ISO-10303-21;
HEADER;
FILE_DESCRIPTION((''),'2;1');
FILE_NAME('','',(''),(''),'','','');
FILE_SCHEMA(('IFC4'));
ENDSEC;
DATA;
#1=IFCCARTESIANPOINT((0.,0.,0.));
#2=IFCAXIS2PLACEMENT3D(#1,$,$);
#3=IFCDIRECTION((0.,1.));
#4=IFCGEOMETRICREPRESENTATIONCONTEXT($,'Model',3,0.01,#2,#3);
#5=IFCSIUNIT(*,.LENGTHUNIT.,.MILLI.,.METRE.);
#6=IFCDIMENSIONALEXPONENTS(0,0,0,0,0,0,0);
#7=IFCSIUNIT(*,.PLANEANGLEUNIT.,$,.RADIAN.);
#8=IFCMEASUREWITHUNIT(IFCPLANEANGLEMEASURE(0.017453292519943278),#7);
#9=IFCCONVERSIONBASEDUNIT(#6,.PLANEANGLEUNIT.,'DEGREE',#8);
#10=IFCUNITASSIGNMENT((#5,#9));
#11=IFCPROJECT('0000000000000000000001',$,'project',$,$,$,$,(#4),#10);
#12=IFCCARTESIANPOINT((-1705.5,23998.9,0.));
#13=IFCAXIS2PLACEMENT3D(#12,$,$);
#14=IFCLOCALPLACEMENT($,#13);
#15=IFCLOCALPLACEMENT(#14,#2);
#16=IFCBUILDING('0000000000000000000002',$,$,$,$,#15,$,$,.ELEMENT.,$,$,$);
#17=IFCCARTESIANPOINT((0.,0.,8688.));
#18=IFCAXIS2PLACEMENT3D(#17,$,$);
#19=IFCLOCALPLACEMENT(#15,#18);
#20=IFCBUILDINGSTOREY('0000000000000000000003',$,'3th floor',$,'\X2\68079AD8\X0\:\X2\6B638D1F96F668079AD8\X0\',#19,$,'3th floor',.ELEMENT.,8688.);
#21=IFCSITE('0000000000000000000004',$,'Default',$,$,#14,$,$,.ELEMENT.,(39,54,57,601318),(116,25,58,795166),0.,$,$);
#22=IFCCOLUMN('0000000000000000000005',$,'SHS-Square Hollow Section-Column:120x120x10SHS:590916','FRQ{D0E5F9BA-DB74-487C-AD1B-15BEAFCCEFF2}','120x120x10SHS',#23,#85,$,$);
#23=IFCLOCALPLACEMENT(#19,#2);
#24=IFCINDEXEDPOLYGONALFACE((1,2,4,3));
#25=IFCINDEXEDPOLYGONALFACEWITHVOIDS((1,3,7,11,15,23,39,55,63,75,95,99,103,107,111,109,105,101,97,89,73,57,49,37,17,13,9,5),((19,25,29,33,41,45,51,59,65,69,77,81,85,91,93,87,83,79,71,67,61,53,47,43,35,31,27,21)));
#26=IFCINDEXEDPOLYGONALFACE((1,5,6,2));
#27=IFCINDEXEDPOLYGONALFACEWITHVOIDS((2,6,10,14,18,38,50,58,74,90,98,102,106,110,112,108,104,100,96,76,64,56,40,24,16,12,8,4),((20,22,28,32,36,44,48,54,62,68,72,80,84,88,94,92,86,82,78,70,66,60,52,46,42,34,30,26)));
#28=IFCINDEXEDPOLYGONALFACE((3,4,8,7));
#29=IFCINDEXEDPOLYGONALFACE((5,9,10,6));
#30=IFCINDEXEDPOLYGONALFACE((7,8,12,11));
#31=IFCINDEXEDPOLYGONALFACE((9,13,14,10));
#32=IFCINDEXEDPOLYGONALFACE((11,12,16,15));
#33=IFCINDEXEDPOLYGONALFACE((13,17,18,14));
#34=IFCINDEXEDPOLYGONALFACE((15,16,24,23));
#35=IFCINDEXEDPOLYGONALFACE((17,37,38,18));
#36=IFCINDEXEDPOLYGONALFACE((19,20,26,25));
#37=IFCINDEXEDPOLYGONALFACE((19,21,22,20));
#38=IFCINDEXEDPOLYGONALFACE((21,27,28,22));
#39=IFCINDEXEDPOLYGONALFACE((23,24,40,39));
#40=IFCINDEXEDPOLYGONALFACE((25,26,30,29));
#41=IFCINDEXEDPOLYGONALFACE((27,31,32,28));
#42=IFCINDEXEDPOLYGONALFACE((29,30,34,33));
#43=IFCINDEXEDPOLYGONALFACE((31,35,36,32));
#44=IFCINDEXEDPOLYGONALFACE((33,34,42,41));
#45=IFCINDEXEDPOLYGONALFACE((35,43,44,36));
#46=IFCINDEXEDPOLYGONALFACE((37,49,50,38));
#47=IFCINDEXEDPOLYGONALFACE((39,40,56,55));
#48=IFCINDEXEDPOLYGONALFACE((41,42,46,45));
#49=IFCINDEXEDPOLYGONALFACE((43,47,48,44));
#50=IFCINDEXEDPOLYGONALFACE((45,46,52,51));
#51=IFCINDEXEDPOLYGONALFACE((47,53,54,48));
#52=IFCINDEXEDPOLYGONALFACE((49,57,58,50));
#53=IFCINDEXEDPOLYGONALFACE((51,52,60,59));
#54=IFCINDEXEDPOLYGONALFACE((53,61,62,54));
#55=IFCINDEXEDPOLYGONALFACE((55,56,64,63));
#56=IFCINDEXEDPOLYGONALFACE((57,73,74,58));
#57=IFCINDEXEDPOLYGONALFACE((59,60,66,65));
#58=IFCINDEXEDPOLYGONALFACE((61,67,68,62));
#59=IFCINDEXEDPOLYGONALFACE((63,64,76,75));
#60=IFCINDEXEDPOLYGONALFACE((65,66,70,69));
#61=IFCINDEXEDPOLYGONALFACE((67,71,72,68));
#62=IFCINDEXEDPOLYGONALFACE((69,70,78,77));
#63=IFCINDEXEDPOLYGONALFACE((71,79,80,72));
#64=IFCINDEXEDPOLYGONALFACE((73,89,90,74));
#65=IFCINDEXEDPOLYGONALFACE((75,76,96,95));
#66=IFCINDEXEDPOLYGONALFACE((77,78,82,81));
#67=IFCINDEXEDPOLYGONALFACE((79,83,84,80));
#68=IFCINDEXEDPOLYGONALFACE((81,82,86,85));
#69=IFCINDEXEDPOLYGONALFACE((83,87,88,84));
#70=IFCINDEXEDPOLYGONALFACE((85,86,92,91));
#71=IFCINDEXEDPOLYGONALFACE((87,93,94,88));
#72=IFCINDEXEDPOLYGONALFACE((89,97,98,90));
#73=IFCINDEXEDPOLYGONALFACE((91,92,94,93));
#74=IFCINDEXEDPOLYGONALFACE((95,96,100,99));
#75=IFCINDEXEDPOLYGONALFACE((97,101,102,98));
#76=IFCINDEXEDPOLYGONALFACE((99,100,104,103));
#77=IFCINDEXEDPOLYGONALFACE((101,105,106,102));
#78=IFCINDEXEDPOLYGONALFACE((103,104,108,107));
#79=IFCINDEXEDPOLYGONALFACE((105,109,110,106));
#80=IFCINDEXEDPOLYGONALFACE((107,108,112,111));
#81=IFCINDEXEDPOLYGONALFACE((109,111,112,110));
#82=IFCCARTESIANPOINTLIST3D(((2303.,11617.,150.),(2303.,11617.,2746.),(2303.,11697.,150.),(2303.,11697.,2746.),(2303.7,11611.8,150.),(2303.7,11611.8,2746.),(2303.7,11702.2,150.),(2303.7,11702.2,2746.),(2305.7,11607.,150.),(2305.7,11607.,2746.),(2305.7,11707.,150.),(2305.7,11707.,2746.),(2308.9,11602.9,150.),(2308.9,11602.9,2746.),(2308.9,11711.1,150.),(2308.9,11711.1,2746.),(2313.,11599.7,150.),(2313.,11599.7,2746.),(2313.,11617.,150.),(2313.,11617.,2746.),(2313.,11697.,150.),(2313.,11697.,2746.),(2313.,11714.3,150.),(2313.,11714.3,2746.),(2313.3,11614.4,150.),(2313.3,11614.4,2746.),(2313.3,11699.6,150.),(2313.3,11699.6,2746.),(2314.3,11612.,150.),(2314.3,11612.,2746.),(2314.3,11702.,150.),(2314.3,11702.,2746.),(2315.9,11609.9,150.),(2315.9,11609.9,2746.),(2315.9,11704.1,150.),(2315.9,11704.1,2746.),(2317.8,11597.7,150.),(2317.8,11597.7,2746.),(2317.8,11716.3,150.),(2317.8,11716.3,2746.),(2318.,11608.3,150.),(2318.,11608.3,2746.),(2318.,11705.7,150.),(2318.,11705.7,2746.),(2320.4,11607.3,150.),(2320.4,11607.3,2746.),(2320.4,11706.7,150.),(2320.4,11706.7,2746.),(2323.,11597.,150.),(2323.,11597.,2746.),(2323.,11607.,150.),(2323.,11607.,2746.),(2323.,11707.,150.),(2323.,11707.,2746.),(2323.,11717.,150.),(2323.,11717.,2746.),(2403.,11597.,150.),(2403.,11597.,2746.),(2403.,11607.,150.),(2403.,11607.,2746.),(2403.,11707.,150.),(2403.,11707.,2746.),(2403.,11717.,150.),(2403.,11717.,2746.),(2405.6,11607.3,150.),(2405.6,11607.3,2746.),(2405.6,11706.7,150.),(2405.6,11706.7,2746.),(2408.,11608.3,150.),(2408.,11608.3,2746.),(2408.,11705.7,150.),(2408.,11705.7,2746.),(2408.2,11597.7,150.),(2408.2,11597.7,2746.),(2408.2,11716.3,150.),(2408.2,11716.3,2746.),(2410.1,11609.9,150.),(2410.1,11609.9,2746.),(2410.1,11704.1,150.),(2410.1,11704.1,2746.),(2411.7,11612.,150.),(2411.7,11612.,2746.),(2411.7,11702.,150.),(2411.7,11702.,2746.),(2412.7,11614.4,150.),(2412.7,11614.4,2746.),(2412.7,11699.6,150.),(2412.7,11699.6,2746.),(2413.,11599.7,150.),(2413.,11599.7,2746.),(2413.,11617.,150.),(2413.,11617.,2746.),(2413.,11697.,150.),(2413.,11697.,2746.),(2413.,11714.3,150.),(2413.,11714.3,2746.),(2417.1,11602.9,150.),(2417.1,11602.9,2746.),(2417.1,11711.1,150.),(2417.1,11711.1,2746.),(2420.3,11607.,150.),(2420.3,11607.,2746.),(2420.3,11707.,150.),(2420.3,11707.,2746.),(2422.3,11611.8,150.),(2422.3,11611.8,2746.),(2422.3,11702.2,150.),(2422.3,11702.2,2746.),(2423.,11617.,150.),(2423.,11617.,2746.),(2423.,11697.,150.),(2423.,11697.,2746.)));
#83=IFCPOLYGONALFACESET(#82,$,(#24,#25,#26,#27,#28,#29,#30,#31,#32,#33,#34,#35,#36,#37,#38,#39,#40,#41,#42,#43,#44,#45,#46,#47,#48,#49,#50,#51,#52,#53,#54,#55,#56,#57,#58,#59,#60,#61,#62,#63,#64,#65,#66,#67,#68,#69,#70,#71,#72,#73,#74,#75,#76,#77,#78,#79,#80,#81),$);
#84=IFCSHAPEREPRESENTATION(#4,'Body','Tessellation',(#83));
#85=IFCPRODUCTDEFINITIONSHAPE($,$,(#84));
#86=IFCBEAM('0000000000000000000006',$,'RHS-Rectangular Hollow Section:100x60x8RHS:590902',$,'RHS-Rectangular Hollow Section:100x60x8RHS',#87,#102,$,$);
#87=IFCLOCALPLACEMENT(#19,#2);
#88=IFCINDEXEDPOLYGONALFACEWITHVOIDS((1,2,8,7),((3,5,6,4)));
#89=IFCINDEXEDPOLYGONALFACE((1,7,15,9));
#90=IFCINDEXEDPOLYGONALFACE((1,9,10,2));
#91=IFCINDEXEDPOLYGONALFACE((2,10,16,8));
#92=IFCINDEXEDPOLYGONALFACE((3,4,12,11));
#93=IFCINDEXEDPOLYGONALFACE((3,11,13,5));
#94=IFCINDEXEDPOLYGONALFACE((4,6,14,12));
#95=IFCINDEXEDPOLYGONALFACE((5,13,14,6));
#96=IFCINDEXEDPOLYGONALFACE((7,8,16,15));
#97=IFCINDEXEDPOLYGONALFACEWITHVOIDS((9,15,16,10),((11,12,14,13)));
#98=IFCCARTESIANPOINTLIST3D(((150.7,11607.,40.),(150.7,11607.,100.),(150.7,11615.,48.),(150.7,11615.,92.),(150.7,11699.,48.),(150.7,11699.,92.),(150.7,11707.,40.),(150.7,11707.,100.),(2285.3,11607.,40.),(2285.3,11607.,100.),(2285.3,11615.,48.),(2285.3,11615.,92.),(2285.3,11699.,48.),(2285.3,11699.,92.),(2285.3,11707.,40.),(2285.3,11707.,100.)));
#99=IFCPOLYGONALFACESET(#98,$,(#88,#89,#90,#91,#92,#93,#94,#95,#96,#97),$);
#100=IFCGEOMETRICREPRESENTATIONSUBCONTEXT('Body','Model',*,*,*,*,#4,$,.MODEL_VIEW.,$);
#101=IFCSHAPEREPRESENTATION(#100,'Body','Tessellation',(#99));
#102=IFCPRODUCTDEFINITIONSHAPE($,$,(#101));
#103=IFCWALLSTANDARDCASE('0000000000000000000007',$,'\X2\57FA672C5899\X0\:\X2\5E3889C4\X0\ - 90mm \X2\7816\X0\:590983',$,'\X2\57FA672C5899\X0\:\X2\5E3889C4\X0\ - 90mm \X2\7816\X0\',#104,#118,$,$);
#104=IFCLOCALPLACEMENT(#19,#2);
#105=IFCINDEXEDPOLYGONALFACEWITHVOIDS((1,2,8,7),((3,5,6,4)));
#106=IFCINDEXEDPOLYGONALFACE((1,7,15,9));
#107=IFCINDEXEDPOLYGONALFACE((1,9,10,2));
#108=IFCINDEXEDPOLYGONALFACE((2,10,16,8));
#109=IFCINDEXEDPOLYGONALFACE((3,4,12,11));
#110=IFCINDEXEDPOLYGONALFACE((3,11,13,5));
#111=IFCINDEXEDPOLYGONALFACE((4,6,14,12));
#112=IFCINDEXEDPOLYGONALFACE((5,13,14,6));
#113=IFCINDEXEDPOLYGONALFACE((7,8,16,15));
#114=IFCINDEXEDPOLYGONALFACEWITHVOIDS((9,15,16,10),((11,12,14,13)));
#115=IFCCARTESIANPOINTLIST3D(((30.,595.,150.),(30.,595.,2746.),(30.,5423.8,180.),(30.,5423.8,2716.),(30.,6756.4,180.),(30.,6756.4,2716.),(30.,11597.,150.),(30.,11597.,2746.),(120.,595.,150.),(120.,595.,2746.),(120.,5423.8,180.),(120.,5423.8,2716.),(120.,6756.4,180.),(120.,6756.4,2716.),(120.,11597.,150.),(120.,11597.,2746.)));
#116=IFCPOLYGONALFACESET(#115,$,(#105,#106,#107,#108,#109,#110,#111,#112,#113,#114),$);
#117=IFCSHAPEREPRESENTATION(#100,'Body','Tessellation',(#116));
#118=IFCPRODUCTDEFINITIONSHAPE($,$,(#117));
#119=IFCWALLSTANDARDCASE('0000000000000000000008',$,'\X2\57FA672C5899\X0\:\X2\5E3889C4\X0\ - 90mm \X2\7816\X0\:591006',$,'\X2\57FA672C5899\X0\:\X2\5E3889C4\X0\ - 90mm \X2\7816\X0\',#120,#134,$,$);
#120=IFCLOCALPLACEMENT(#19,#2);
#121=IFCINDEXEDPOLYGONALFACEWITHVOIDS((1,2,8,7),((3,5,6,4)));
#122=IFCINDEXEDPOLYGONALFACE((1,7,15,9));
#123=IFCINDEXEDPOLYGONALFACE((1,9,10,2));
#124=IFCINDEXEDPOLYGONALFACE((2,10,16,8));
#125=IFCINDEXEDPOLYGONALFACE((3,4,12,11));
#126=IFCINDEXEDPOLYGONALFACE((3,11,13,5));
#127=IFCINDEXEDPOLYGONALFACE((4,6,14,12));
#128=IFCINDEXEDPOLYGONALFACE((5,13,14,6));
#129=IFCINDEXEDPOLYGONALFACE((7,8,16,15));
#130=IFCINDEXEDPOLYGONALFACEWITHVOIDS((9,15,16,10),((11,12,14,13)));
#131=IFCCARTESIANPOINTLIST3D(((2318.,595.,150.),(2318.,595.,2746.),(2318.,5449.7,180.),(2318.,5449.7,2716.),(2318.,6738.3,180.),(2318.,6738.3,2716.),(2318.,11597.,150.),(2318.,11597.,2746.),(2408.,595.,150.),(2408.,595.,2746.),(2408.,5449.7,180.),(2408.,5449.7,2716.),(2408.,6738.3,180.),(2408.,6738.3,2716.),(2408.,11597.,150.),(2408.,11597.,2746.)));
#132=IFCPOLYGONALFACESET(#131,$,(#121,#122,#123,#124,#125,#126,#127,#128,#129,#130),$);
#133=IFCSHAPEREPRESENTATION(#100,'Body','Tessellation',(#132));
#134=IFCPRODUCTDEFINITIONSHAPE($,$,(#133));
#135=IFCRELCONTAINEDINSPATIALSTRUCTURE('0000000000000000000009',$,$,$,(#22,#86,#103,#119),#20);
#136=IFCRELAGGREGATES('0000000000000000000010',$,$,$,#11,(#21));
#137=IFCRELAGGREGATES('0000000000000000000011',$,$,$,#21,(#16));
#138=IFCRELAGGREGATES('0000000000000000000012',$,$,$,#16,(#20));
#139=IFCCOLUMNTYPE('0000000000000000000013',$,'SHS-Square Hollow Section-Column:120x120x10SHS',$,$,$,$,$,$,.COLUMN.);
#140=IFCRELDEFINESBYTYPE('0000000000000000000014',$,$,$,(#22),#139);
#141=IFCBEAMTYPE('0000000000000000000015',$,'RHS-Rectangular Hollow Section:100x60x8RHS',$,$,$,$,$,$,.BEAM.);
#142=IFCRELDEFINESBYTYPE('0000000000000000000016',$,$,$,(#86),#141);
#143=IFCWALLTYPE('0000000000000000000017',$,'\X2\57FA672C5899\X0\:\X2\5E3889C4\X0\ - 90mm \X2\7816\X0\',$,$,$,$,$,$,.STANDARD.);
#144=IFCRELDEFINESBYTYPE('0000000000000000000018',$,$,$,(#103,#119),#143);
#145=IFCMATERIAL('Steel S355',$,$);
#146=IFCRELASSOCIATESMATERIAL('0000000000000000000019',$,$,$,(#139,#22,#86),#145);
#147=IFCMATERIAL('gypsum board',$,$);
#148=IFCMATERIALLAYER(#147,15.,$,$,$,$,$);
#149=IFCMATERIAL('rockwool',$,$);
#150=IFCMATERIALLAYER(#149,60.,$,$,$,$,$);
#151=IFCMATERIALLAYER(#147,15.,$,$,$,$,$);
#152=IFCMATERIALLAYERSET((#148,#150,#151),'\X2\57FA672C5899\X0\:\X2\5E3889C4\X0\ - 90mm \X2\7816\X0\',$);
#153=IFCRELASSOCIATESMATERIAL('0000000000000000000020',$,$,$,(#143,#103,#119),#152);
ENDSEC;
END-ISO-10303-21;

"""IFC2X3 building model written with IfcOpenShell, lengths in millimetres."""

from ifc_helpers import new_model, entity, si_unit, converted_unit, direction, frame, frame_2d, origin, origin_2d, place, context, subcontext, project, spatial, rectangle, hollow_rectangle, extrude, boolean, clip, halfspace, material, layer, layer_set, layer_usage, type_object, element, save


model = new_model("IFC2X3")

# Units and contexts
model_context = context("Model", 3, precision=0.01, world=origin(), true_north=direction((0.0, 1.0)))
body_context = subcontext(model_context, "Body", "Model", "MODEL_VIEW")
ifc_project = project(units=[si_unit("LENGTHUNIT", "METRE", prefix="MILLI"), converted_unit("PLANEANGLEUNIT", "DEGREE", entity("IfcPlaneAngleMeasure", 0.017453292519943278), si_unit("PLANEANGLEUNIT", "RADIAN"), dimensions=[0, 0, 0, 0, 0, 0, 0])], contexts=[model_context])

# Site, building, storey
site_placement = place(None, frame((-1705.5, 23998.9, 0.0)))
site = spatial("IfcSite", under=ifc_project, at=site_placement, Name="Default", CompositionType="ELEMENT", RefLatitude=(39, 54, 57, 601318), RefLongitude=(116, 25, 58, 795166), RefElevation=0.0)
building_placement = place(site_placement, origin())
building = spatial("IfcBuilding", under=site, at=building_placement, CompositionType="ELEMENT")
storey_placement = place(building_placement, frame((0.0, 0.0, 8688.0)))
storey = spatial("IfcBuildingStorey", under=building, at=storey_placement, Name="3th floor", ObjectType="标高:正负零标高", LongName="3th floor", CompositionType="ELEMENT", Elevation=8688.0)

# Shared definitions
ifc_material_1 = material(Name="Steel S355")

# Column
column_type_1 = type_object("IfcColumnType", Name="SHS-Square Hollow Section-Column:120x120x10SHS", PredefinedType="COLUMN", material=ifc_material_1)
column_1_placement = place(storey_placement, frame((2363.0, 11657.0, 2830.9), z_axis=(0.0, 0.0, 1.0), x_axis=(0.0, -1.0, 0.0)))
element("IfcColumn", 1, at=column_1_placement, inside=storey, type_object=column_type_1, material=ifc_material_1, Name="SHS-Square Hollow Section-Column:120x120x10SHS:590916", Description="FRQ{D0E5F9BA-DB74-487C-AD1B-15BEAFCCEFF2}", ObjectType="120x120x10SHS", context=model_context, shape_type="Clipping", body=[
    clip(clip(extrude(hollow_rectangle(XDim=120.0, YDim=120.0, WallThickness=10.0, InnerFilletRadius=10.0, OuterFilletRadius=20.0, at=origin_2d()), origin(), (0.0, 0.0, -1.0), 2765.7), halfspace(frame((11657.0, -2363.0, -84.9), z_axis=(0.0, 0.0, -1.0), x_axis=(0.0, -1.0, 0.0)), True)), halfspace(frame((11657.0, -2363.0, -2680.9), z_axis=(0.0, 0.0, 1.0), x_axis=(0.0, 1.0, 0.0)), True)),
])

# Beam
beam_type_1 = type_object("IfcBeamType", Name="RHS-Rectangular Hollow Section:100x60x8RHS", PredefinedType="BEAM")
beam_1_placement = place(storey_placement, frame((150.7, 11707.0, 70.0)))
element("IfcBeam", 2, at=beam_1_placement, inside=storey, type_object=beam_type_1, material=ifc_material_1, Name="RHS-Rectangular Hollow Section:100x60x8RHS:590902", ObjectType="RHS-Rectangular Hollow Section:100x60x8RHS", context=body_context, shape_type="SweptSolid", body=[
    boolean("DIFFERENCE", extrude(rectangle(XDim=60.0, YDim=100.0, at=frame_2d((0.0, 0.0), x_axis=(1.0, 0.0))), frame((0.0, -50.0, 0.0), z_axis=(1.0, 0.0, 0.0), x_axis=(0.0, 0.0, -1.0)), (0.0, 0.0, 1.0), 2134.6), extrude(rectangle(XDim=44.0, YDim=84.0, at=frame_2d((0.0, 0.0), x_axis=(0.0, 1.0))), frame((2134.6, -50.0, 0.0), z_axis=(-1.0, 0.0, 0.0), x_axis=(0.0, 1.0, 0.0)), (0.0, 0.0, 1.0), 2134.6)),
])

# Wall, opening
ifc_material_2 = material(Name="gypsum board")
ifc_layer_1 = layer(ifc_material_2, 15.0)
ifc_material_3 = material(Name="rockwool")
ifc_layer_2 = layer(ifc_material_3, 60.0)
ifc_layer_3 = layer(ifc_material_2, 15.0)
ifc_layer_set = layer_set([ifc_layer_1, ifc_layer_2, ifc_layer_3], Name="基本墙:常规 - 90mm 砖")
ifc_layer_usage_1 = layer_usage(ifc_layer_set, "AXIS2", "NEGATIVE", 45.0)
wall_type = type_object("IfcWallType", Name="基本墙:常规 - 90mm 砖", PredefinedType="STANDARD", material=ifc_layer_set)
wall_1_placement = place(storey_placement, frame((75.0, 11597.0, 150.0), z_axis=(0.0, 0.0, 1.0), x_axis=(0.0, -1.0, 0.0)))
wall_1 = element("IfcWallStandardCase", 3, at=wall_1_placement, inside=storey, type_object=wall_type, material=ifc_layer_usage_1, Name="基本墙:常规 - 90mm 砖:590983", ObjectType="基本墙:常规 - 90mm 砖", context=body_context, shape_type="SweptSolid", body=[
    extrude(rectangle(XDim=11002.0, YDim=90.0, at=frame_2d((5501.0, 0.0), x_axis=(-1.0, 0.0))), origin(), (0.0, 0.0, 1.0), 2596.0),
])
opening_1_placement = place(wall_1_placement, origin())
element("IfcOpeningElement", 4, at=opening_1_placement, cuts=wall_1, ObjectType="Opening", context=body_context, shape_type="SweptSolid", body=[
    extrude(rectangle(XDim=2536.0, YDim=1332.6, at=frame_2d((0.0, 0.0), x_axis=(0.0, 1.0))), frame((5506.9, 45.0, 1298.0), z_axis=(0.0, -1.0, 0.0), x_axis=(-1.0, 0.0, 0.0)), (0.0, 0.0, 1.0), 90.0),
])

# Wall, opening
ifc_layer_usage_2 = layer_usage(ifc_layer_set, "AXIS2", "NEGATIVE", 45.0)
wall_2_placement = place(storey_placement, frame((2363.0, 11597.0, 150.0), z_axis=(0.0, 0.0, 1.0), x_axis=(0.0, -1.0, 0.0)))
wall_2 = element("IfcWallStandardCase", 5, at=wall_2_placement, inside=storey, type_object=wall_type, material=ifc_layer_usage_2, Name="基本墙:常规 - 90mm 砖:591006", ObjectType="基本墙:常规 - 90mm 砖", context=body_context, shape_type="SweptSolid", body=[
    extrude(rectangle(XDim=11002.0, YDim=90.0, at=frame_2d((5501.0, 0.0), x_axis=(-1.0, 0.0))), origin(), (0.0, 0.0, 1.0), 2596.0),
])
opening_2_placement = place(wall_2_placement, origin())
element("IfcOpeningElement", 6, at=opening_2_placement, cuts=wall_2, ObjectType="Opening", context=body_context, shape_type="SweptSolid", body=[
    extrude(rectangle(XDim=2536.0, YDim=1288.6, at=frame_2d((0.0, 0.0), x_axis=(0.0, 1.0))), frame((5503.0, 45.0, 1298.0), z_axis=(0.0, -1.0, 0.0), x_axis=(-1.0, 0.0, 0.0)), (0.0, 0.0, 1.0), 90.0),
])

save(model, "model.ifc")
